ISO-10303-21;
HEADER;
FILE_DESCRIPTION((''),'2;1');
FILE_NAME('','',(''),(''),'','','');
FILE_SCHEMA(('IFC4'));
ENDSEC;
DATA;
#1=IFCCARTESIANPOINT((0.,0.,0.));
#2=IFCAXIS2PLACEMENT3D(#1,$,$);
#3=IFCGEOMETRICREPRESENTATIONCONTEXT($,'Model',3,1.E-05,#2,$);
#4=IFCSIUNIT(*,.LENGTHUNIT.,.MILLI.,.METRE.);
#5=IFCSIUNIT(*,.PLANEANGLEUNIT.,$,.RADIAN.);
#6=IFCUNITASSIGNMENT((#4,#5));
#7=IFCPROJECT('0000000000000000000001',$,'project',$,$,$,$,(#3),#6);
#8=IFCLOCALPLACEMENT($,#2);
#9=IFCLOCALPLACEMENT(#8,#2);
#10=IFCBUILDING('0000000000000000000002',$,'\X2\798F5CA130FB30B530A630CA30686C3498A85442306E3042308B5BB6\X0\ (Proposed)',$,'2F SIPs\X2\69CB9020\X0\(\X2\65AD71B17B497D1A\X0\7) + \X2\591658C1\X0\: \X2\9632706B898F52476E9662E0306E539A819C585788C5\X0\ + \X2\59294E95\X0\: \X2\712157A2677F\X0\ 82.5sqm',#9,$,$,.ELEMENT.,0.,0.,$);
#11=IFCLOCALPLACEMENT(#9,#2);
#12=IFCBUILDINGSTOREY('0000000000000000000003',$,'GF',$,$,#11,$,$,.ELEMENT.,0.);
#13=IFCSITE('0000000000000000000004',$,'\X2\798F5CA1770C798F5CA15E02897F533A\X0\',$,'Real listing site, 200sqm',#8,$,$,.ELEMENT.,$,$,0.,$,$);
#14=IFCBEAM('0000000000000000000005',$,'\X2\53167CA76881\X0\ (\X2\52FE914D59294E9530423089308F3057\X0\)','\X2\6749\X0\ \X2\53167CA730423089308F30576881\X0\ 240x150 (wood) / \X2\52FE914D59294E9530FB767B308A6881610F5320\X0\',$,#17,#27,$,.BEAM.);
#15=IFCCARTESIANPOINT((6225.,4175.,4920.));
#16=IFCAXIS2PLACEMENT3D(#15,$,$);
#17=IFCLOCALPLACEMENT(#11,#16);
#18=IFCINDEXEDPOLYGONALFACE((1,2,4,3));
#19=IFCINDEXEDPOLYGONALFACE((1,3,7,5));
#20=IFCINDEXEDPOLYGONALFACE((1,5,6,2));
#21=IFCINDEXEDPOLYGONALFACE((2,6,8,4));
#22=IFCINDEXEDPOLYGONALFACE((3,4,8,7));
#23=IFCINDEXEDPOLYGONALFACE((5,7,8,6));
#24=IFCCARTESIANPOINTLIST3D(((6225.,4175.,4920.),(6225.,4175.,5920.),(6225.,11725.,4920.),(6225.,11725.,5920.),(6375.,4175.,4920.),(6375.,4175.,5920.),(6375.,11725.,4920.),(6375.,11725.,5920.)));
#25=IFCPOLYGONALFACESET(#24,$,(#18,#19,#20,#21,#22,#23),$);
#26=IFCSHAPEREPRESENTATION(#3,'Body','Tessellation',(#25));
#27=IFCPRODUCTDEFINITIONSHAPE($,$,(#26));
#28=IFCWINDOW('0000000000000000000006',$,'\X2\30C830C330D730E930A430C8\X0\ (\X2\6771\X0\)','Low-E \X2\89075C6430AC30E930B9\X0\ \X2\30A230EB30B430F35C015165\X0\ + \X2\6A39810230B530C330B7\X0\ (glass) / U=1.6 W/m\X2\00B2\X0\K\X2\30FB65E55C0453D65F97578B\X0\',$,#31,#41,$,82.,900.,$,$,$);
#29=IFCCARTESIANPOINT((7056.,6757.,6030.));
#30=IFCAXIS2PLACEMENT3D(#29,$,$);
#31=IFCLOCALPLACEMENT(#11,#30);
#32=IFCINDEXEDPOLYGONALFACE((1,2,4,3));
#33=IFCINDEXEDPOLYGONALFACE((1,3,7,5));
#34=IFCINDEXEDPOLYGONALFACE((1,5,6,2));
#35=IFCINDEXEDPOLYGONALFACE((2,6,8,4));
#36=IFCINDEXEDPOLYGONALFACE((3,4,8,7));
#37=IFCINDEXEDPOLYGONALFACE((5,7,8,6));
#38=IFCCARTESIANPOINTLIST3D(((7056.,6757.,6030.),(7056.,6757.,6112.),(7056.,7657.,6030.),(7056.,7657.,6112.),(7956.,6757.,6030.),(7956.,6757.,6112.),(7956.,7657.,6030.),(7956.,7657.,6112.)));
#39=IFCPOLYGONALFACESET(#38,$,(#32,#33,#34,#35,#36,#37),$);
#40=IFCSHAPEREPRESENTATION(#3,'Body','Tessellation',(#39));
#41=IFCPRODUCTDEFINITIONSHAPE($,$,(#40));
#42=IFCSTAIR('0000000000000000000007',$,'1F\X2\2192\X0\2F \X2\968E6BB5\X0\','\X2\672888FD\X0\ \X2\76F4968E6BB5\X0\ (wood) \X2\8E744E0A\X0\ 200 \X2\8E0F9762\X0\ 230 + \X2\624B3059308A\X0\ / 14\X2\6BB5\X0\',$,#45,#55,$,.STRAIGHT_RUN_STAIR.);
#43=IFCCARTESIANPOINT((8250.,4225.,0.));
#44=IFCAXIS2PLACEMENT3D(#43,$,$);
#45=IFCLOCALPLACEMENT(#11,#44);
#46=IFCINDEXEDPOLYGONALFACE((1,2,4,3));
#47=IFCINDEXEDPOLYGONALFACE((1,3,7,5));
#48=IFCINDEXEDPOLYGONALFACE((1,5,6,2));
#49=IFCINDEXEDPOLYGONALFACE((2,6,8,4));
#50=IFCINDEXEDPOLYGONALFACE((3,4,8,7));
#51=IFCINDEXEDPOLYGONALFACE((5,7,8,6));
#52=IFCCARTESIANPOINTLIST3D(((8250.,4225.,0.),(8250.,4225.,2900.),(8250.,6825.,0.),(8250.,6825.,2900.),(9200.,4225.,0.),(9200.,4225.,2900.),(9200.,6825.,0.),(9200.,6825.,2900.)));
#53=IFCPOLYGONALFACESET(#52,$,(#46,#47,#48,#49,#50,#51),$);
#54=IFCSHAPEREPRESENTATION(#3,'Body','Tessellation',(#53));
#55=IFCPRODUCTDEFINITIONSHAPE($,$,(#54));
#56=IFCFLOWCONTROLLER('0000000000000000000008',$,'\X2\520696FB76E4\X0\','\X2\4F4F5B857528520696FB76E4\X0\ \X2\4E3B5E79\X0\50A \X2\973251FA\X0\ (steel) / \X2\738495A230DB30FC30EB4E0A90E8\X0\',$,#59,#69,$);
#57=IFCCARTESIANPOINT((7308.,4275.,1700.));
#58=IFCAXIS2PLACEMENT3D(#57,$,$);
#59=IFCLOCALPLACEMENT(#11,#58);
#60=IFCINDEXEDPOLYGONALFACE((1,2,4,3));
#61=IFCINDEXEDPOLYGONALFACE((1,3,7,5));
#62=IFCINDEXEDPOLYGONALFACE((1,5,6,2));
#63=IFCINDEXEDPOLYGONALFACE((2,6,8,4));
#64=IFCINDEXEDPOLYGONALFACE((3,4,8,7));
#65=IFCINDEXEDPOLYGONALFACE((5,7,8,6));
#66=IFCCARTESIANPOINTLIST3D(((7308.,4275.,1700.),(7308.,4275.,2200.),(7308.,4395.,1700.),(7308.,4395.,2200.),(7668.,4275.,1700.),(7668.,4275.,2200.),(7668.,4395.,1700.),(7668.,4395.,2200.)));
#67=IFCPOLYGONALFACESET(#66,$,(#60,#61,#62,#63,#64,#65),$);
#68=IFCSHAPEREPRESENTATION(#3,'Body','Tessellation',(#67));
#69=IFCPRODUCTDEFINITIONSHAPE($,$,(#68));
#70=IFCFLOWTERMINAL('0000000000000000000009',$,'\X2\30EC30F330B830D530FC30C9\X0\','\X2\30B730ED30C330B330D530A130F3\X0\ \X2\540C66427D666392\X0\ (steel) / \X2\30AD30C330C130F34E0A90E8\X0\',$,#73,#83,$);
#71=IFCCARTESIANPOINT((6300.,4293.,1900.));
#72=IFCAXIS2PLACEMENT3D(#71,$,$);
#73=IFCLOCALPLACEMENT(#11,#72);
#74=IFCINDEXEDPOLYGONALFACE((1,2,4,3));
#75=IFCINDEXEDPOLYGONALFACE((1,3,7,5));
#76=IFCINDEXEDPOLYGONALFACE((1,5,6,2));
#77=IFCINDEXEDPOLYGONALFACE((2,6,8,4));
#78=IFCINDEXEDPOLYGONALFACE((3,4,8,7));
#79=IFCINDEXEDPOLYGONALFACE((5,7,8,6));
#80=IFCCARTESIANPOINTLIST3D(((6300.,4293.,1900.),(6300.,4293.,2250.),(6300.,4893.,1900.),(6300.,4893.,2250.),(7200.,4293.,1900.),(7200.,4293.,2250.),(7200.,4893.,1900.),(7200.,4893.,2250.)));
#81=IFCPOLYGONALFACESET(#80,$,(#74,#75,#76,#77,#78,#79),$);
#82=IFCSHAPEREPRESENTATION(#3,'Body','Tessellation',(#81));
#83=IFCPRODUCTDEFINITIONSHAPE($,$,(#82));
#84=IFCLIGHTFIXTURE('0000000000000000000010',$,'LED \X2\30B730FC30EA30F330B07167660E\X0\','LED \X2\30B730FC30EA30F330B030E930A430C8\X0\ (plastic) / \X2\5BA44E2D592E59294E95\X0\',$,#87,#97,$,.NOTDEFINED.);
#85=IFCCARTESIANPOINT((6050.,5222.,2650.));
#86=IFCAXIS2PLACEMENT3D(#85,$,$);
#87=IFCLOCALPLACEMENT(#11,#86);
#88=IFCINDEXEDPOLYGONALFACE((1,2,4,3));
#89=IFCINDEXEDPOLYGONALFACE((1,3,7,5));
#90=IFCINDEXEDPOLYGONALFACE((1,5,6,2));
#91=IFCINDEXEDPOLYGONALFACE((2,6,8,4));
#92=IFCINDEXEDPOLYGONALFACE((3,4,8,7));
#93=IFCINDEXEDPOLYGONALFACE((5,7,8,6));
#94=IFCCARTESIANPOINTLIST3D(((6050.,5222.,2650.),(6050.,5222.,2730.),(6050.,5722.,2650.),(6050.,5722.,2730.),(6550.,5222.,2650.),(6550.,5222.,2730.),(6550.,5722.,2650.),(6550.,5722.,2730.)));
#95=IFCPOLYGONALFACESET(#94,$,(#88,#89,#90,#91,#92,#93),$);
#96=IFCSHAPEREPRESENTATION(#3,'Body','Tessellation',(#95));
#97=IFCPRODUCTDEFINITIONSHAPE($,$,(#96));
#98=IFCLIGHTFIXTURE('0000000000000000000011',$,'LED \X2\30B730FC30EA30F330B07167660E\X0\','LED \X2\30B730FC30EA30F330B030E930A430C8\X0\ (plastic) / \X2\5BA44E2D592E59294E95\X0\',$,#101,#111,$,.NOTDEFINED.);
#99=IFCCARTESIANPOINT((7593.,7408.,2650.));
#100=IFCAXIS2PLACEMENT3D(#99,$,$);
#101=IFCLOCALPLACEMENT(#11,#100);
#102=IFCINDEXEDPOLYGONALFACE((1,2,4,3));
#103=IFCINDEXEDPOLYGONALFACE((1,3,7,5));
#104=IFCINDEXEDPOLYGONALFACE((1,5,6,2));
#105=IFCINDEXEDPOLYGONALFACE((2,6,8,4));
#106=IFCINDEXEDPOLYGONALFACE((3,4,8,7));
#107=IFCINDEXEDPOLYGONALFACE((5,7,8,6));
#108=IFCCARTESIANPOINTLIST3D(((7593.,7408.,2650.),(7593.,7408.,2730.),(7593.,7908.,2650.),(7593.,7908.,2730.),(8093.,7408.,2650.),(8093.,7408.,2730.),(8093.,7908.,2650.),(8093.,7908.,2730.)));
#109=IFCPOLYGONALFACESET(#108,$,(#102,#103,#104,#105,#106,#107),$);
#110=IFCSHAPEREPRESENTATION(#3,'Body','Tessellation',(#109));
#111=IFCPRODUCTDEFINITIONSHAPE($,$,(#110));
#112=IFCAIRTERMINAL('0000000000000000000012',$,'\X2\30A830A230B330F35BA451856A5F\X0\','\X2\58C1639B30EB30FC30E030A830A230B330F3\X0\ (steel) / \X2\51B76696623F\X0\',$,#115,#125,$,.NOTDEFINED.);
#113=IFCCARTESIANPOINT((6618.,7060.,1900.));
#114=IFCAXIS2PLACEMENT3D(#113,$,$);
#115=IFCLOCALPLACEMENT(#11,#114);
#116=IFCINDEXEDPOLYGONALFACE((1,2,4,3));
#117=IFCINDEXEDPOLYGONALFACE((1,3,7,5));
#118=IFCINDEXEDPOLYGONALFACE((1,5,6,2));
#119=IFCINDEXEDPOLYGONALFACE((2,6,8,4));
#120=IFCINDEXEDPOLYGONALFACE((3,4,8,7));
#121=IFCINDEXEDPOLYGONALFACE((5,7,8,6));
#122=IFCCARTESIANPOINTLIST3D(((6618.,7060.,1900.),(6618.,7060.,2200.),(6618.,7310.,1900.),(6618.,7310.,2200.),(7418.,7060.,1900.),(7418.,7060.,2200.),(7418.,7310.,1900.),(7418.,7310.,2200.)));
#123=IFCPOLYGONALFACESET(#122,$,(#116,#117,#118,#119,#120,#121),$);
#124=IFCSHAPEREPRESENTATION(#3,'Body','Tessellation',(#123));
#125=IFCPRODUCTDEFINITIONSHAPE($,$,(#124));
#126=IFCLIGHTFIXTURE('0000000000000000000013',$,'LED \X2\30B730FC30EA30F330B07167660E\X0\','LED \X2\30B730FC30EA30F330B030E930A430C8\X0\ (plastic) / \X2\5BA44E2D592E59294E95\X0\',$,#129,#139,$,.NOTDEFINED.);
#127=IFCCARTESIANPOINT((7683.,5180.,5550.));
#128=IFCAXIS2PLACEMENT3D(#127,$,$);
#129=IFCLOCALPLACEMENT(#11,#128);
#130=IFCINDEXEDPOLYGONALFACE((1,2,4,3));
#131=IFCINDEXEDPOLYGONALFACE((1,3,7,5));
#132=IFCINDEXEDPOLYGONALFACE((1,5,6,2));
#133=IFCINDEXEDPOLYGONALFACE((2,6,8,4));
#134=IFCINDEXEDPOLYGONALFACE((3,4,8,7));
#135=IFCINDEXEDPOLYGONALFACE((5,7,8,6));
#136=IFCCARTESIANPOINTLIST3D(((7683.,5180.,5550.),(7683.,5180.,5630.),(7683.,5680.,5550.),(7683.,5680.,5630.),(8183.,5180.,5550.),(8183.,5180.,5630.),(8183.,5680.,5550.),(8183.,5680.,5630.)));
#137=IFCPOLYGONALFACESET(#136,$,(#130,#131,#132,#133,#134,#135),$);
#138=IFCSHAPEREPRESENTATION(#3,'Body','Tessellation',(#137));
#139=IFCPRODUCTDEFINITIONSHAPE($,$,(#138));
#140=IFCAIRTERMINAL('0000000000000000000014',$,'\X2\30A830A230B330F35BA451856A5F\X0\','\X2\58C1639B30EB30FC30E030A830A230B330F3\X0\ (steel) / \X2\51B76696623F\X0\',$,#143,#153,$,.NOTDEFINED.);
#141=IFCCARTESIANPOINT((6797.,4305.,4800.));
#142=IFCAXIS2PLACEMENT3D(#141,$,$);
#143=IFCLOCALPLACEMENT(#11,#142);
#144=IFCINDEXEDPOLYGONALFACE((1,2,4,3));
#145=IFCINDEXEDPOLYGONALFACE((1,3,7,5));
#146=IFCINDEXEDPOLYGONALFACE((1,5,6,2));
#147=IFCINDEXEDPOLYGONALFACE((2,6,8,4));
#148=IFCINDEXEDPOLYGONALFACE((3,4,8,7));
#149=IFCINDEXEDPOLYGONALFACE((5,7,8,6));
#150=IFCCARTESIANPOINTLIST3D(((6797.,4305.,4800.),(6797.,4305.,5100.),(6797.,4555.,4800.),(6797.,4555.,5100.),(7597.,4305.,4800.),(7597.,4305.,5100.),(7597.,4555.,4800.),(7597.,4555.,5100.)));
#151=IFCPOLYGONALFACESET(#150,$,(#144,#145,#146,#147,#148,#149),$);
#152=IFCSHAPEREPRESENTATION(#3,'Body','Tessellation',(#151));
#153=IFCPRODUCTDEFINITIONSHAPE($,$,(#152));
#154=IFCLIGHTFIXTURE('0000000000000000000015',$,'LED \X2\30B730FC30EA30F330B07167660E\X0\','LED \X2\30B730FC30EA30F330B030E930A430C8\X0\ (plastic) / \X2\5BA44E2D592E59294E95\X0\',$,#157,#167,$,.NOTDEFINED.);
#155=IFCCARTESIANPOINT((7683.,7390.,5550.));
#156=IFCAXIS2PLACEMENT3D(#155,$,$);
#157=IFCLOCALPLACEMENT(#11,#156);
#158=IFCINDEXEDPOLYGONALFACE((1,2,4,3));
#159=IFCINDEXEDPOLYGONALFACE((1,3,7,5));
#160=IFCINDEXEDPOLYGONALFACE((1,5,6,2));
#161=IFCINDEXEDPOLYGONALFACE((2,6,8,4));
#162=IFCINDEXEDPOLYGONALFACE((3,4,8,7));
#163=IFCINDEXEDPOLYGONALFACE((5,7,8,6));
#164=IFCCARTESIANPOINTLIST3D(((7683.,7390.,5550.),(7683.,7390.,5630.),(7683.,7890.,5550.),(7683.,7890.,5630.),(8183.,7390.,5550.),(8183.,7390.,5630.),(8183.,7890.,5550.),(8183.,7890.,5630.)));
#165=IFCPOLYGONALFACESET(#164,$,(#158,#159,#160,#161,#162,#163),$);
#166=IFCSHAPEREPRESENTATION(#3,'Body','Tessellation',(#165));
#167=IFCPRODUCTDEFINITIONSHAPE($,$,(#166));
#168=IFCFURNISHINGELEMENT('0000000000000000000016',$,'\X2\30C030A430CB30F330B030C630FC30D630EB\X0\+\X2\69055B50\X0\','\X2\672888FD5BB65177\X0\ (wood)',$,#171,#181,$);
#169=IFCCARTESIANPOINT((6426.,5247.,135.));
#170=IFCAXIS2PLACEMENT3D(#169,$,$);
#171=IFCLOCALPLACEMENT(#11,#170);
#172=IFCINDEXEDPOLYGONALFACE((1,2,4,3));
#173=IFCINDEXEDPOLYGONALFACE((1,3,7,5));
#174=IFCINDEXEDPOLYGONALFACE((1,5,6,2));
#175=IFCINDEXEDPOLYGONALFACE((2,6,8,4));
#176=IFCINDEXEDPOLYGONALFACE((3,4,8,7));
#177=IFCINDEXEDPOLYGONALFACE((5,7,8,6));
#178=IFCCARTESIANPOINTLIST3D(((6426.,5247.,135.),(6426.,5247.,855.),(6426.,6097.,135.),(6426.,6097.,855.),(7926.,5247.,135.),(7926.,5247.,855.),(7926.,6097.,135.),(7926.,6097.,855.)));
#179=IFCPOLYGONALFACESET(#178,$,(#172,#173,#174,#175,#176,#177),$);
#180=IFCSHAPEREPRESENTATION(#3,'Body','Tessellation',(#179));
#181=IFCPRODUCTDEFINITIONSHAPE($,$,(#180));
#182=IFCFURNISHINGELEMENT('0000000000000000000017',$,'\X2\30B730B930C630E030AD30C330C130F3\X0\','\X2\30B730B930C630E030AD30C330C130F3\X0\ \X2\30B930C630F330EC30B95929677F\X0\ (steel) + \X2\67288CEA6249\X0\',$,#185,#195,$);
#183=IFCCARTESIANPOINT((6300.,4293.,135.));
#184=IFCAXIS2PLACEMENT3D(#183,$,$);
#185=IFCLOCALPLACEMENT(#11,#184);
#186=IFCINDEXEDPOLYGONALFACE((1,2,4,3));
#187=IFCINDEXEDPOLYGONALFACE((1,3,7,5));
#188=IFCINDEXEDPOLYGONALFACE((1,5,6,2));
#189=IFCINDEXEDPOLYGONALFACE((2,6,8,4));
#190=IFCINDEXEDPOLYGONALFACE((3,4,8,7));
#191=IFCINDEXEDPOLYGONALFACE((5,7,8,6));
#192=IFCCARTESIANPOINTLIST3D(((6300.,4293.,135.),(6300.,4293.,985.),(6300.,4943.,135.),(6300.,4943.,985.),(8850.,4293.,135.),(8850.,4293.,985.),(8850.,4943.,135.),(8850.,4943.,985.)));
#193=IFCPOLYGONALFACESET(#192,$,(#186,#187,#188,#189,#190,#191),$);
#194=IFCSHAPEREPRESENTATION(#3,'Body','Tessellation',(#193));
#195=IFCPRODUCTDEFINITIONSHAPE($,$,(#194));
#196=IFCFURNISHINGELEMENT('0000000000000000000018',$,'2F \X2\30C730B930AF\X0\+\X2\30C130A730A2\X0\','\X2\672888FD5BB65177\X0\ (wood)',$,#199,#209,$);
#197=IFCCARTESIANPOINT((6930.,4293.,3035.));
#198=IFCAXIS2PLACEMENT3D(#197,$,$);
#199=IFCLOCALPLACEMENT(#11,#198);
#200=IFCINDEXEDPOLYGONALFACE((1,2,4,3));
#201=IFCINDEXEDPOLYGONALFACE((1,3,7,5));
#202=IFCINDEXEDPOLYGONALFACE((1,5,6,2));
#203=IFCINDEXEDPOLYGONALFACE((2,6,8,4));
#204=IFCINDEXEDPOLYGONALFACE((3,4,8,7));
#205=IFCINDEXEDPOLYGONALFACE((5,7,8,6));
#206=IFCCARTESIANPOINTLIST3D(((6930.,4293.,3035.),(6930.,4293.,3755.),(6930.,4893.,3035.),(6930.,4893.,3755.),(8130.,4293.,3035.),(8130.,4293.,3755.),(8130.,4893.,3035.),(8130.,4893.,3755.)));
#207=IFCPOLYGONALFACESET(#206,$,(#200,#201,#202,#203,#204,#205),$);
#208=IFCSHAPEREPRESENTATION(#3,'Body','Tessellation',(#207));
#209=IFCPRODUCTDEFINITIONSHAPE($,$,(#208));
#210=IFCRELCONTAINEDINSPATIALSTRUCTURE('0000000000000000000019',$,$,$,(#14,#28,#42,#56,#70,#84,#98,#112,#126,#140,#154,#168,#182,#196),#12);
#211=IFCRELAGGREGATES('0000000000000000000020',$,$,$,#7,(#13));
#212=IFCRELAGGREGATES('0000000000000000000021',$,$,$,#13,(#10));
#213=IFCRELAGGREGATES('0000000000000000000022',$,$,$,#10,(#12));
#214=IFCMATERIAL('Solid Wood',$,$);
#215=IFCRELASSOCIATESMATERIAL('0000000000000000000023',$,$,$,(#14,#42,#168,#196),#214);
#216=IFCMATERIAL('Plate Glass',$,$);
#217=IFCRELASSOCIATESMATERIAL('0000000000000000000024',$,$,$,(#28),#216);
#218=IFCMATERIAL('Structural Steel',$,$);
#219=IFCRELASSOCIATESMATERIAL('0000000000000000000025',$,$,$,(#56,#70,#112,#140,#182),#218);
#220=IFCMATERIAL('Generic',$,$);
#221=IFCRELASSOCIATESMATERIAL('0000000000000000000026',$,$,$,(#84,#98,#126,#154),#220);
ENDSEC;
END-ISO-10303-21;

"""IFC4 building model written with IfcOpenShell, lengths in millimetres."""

from ifc_helpers import new_model, si_unit, frame, frame_2d, origin, place, context, project, spatial, rectangle, extrude, material, element, save


model = new_model("IFC4")

# Units and contexts
model_context = context("Model", 3, precision=1e-05, world=origin())
ifc_project = project(units=[si_unit("LENGTHUNIT", "METRE", prefix="MILLI"), si_unit("PLANEANGLEUNIT", "RADIAN")], contexts=[model_context])

# Site, building, storey
site_placement = place(None, origin())
site = spatial("IfcSite", under=ifc_project, at=site_placement, Name="福岡県福岡市西区", ObjectType="Real listing site, 200sqm", CompositionType="ELEMENT", RefElevation=0.0)
building_placement = place(site_placement, origin())
building = spatial("IfcBuilding", under=site, at=building_placement, Name="福岡・サウナと水風呂のある家 (Proposed)", ObjectType="2F SIPs構造(断熱等級7) + 外壁: 防火規則準拠の厚膜塗装 + 天井: 無垢板 82.5sqm", CompositionType="ELEMENT", ElevationOfRefHeight=0.0, ElevationOfTerrain=0.0)
storey_placement = place(building_placement, origin())
storey = spatial("IfcBuildingStorey", under=building, at=storey_placement, Name="GF", CompositionType="ELEMENT", Elevation=0.0)

# Shared definitions
ifc_material_1 = material(Name="Solid Wood")

# Beam
beam_placement = place(storey_placement, frame((6225.0, 4175.0, 4920.0)))
element("IfcBeam", 1, at=beam_placement, inside=storey, material=ifc_material_1, Name="化粧梁 (勾配天井あらわし)", Description="杉 化粧あらわし梁 240x150 (wood) / 勾配天井・登り梁意匠", PredefinedType="BEAM", context=model_context, shape_type="SweptSolid", body=[
    extrude(rectangle(XDim=150.0, YDim=7550.0, at=frame_2d((75.0, 3775.0))), frame((6225.0, 4175.0, 4920.0)), (0.0, 0.0, 1.0), 1000.0),
])

# Window
ifc_material_2 = material(Name="Plate Glass")
window_placement = place(storey_placement, frame((7056.0, 6757.0, 6030.0)))
element("IfcWindow", 2, at=window_placement, inside=storey, material=ifc_material_2, Name="トップライト (東)", Description="Low-E 複層ガラス アルゴン封入 + 樹脂サッシ (glass) / U=1.6 W/m²K・日射取得型", OverallHeight=82.0, OverallWidth=900.0, context=model_context, shape_type="SweptSolid", body=[
    extrude(rectangle(XDim=900.0, YDim=900.0, at=frame_2d((450.0, 450.0))), frame((7056.0, 6757.0, 6030.0)), (0.0, 0.0, 1.0), 82.0),
])

# Stair
stair_placement = place(storey_placement, frame((8250.0, 4225.0, 0.0)))
element("IfcStair", 3, at=stair_placement, inside=storey, material=ifc_material_1, Name="1F→2F 階段", Description="木製 直階段 (wood) 蹴上 200 踏面 230 + 手すり / 14段", PredefinedType="STRAIGHT_RUN_STAIR", context=model_context, shape_type="SweptSolid", body=[
    extrude(rectangle(XDim=950.0, YDim=2600.0, at=frame_2d((475.0, 1300.0))), frame((8250.0, 4225.0, 0.0)), (0.0, 0.0, 1.0), 2900.0),
])

# Flow controller
ifc_material_3 = material(Name="Structural Steel")
flow_controller_placement = place(storey_placement, frame((7308.0, 4275.0, 1700.0)))
element("IfcFlowController", 4, at=flow_controller_placement, inside=storey, material=ifc_material_3, Name="分電盤", Description="住宅用分電盤 主幹50A 露出 (steel) / 玄関ホール上部", context=model_context, shape_type="SweptSolid", body=[
    extrude(rectangle(XDim=360.0, YDim=120.0, at=frame_2d((180.0, 60.0))), frame((7308.0, 4275.0, 1700.0)), (0.0, 0.0, 1.0), 500.0),
])

# Flow terminal
flow_terminal_placement = place(storey_placement, frame((6300.0, 4293.0, 1900.0)))
element("IfcFlowTerminal", 5, at=flow_terminal_placement, inside=storey, material=ifc_material_3, Name="レンジフード", Description="シロッコファン 同時給排 (steel) / キッチン上部", context=model_context, shape_type="SweptSolid", body=[
    extrude(rectangle(XDim=900.0, YDim=600.0, at=frame_2d((450.0, 300.0))), frame((6300.0, 4293.0, 1900.0)), (0.0, 0.0, 1.0), 350.0),
])

# Light fixtures
ifc_material_4 = material(Name="Generic")
light_fixture_1_placement = place(storey_placement, frame((6050.0, 5222.0, 2650.0)))
element("IfcLightFixture", 6, at=light_fixture_1_placement, inside=storey, material=ifc_material_4, Name="LED シーリング照明", Description="LED シーリングライト (plastic) / 室中央天井", PredefinedType="NOTDEFINED", context=model_context, shape_type="SweptSolid", body=[
    extrude(rectangle(XDim=500.0, YDim=500.0, at=frame_2d((250.0, 250.0))), frame((6050.0, 5222.0, 2650.0)), (0.0, 0.0, 1.0), 80.0),
])
light_fixture_2_placement = place(storey_placement, frame((7593.0, 7408.0, 2650.0)))
element("IfcLightFixture", 7, at=light_fixture_2_placement, inside=storey, material=ifc_material_4, Name="LED シーリング照明", Description="LED シーリングライト (plastic) / 室中央天井", PredefinedType="NOTDEFINED", context=model_context, shape_type="SweptSolid", body=[
    extrude(rectangle(XDim=500.0, YDim=500.0, at=frame_2d((250.0, 250.0))), frame((7593.0, 7408.0, 2650.0)), (0.0, 0.0, 1.0), 80.0),
])

# Air terminal
air_terminal_1_placement = place(storey_placement, frame((6618.0, 7060.0, 1900.0)))
element("IfcAirTerminal", 8, at=air_terminal_1_placement, inside=storey, material=ifc_material_3, Name="エアコン室内機", Description="壁掛ルームエアコン (steel) / 冷暖房", PredefinedType="NOTDEFINED", context=model_context, shape_type="SweptSolid", body=[
    extrude(rectangle(XDim=800.0, YDim=250.0, at=frame_2d((400.0, 125.0))), frame((6618.0, 7060.0, 1900.0)), (0.0, 0.0, 1.0), 300.0),
])

# Light fixture
light_fixture_3_placement = place(storey_placement, frame((7683.0, 5180.0, 5550.0)))
element("IfcLightFixture", 9, at=light_fixture_3_placement, inside=storey, material=ifc_material_4, Name="LED シーリング照明", Description="LED シーリングライト (plastic) / 室中央天井", PredefinedType="NOTDEFINED", context=model_context, shape_type="SweptSolid", body=[
    extrude(rectangle(XDim=500.0, YDim=500.0, at=frame_2d((250.0, 250.0))), frame((7683.0, 5180.0, 5550.0)), (0.0, 0.0, 1.0), 80.0),
])

# Air terminal
air_terminal_2_placement = place(storey_placement, frame((6797.0, 4305.0, 4800.0)))
element("IfcAirTerminal", 10, at=air_terminal_2_placement, inside=storey, material=ifc_material_3, Name="エアコン室内機", Description="壁掛ルームエアコン (steel) / 冷暖房", PredefinedType="NOTDEFINED", context=model_context, shape_type="SweptSolid", body=[
    extrude(rectangle(XDim=800.0, YDim=250.0, at=frame_2d((400.0, 125.0))), frame((6797.0, 4305.0, 4800.0)), (0.0, 0.0, 1.0), 300.0),
])

# Light fixture
light_fixture_4_placement = place(storey_placement, frame((7683.0, 7390.0, 5550.0)))
element("IfcLightFixture", 11, at=light_fixture_4_placement, inside=storey, material=ifc_material_4, Name="LED シーリング照明", Description="LED シーリングライト (plastic) / 室中央天井", PredefinedType="NOTDEFINED", context=model_context, shape_type="SweptSolid", body=[
    extrude(rectangle(XDim=500.0, YDim=500.0, at=frame_2d((250.0, 250.0))), frame((7683.0, 7390.0, 5550.0)), (0.0, 0.0, 1.0), 80.0),
])

# Furnishing elements
furnishing_1_placement = place(storey_placement, frame((6426.0, 5247.0, 135.0)))
element("IfcFurnishingElement", 12, at=furnishing_1_placement, inside=storey, material=ifc_material_1, Name="ダイニングテーブル+椅子", Description="木製家具 (wood)", context=model_context, shape_type="SweptSolid", body=[
    extrude(rectangle(XDim=1500.0, YDim=850.0, at=frame_2d((750.0, 425.0))), frame((6426.0, 5247.0, 135.0)), (0.0, 0.0, 1.0), 720.0),
])
furnishing_2_placement = place(storey_placement, frame((6300.0, 4293.0, 135.0)))
element("IfcFurnishingElement", 13, at=furnishing_2_placement, inside=storey, material=ifc_material_3, Name="システムキッチン", Description="システムキッチン ステンレス天板 (steel) + 木質扉", context=model_context, shape_type="SweptSolid", body=[
    extrude(rectangle(XDim=2550.0, YDim=650.0, at=frame_2d((1275.0, 325.0))), frame((6300.0, 4293.0, 135.0)), (0.0, 0.0, 1.0), 850.0),
])
furnishing_3_placement = place(storey_placement, frame((6930.0, 4293.0, 3035.0)))
element("IfcFurnishingElement", 14, at=furnishing_3_placement, inside=storey, material=ifc_material_1, Name="2F デスク+チェア", Description="木製家具 (wood)", context=model_context, shape_type="SweptSolid", body=[
    extrude(rectangle(XDim=1200.0, YDim=600.0, at=frame_2d((600.0, 300.0))), frame((6930.0, 4293.0, 3035.0)), (0.0, 0.0, 1.0), 720.0),
])

save(model, "model.ifc")
